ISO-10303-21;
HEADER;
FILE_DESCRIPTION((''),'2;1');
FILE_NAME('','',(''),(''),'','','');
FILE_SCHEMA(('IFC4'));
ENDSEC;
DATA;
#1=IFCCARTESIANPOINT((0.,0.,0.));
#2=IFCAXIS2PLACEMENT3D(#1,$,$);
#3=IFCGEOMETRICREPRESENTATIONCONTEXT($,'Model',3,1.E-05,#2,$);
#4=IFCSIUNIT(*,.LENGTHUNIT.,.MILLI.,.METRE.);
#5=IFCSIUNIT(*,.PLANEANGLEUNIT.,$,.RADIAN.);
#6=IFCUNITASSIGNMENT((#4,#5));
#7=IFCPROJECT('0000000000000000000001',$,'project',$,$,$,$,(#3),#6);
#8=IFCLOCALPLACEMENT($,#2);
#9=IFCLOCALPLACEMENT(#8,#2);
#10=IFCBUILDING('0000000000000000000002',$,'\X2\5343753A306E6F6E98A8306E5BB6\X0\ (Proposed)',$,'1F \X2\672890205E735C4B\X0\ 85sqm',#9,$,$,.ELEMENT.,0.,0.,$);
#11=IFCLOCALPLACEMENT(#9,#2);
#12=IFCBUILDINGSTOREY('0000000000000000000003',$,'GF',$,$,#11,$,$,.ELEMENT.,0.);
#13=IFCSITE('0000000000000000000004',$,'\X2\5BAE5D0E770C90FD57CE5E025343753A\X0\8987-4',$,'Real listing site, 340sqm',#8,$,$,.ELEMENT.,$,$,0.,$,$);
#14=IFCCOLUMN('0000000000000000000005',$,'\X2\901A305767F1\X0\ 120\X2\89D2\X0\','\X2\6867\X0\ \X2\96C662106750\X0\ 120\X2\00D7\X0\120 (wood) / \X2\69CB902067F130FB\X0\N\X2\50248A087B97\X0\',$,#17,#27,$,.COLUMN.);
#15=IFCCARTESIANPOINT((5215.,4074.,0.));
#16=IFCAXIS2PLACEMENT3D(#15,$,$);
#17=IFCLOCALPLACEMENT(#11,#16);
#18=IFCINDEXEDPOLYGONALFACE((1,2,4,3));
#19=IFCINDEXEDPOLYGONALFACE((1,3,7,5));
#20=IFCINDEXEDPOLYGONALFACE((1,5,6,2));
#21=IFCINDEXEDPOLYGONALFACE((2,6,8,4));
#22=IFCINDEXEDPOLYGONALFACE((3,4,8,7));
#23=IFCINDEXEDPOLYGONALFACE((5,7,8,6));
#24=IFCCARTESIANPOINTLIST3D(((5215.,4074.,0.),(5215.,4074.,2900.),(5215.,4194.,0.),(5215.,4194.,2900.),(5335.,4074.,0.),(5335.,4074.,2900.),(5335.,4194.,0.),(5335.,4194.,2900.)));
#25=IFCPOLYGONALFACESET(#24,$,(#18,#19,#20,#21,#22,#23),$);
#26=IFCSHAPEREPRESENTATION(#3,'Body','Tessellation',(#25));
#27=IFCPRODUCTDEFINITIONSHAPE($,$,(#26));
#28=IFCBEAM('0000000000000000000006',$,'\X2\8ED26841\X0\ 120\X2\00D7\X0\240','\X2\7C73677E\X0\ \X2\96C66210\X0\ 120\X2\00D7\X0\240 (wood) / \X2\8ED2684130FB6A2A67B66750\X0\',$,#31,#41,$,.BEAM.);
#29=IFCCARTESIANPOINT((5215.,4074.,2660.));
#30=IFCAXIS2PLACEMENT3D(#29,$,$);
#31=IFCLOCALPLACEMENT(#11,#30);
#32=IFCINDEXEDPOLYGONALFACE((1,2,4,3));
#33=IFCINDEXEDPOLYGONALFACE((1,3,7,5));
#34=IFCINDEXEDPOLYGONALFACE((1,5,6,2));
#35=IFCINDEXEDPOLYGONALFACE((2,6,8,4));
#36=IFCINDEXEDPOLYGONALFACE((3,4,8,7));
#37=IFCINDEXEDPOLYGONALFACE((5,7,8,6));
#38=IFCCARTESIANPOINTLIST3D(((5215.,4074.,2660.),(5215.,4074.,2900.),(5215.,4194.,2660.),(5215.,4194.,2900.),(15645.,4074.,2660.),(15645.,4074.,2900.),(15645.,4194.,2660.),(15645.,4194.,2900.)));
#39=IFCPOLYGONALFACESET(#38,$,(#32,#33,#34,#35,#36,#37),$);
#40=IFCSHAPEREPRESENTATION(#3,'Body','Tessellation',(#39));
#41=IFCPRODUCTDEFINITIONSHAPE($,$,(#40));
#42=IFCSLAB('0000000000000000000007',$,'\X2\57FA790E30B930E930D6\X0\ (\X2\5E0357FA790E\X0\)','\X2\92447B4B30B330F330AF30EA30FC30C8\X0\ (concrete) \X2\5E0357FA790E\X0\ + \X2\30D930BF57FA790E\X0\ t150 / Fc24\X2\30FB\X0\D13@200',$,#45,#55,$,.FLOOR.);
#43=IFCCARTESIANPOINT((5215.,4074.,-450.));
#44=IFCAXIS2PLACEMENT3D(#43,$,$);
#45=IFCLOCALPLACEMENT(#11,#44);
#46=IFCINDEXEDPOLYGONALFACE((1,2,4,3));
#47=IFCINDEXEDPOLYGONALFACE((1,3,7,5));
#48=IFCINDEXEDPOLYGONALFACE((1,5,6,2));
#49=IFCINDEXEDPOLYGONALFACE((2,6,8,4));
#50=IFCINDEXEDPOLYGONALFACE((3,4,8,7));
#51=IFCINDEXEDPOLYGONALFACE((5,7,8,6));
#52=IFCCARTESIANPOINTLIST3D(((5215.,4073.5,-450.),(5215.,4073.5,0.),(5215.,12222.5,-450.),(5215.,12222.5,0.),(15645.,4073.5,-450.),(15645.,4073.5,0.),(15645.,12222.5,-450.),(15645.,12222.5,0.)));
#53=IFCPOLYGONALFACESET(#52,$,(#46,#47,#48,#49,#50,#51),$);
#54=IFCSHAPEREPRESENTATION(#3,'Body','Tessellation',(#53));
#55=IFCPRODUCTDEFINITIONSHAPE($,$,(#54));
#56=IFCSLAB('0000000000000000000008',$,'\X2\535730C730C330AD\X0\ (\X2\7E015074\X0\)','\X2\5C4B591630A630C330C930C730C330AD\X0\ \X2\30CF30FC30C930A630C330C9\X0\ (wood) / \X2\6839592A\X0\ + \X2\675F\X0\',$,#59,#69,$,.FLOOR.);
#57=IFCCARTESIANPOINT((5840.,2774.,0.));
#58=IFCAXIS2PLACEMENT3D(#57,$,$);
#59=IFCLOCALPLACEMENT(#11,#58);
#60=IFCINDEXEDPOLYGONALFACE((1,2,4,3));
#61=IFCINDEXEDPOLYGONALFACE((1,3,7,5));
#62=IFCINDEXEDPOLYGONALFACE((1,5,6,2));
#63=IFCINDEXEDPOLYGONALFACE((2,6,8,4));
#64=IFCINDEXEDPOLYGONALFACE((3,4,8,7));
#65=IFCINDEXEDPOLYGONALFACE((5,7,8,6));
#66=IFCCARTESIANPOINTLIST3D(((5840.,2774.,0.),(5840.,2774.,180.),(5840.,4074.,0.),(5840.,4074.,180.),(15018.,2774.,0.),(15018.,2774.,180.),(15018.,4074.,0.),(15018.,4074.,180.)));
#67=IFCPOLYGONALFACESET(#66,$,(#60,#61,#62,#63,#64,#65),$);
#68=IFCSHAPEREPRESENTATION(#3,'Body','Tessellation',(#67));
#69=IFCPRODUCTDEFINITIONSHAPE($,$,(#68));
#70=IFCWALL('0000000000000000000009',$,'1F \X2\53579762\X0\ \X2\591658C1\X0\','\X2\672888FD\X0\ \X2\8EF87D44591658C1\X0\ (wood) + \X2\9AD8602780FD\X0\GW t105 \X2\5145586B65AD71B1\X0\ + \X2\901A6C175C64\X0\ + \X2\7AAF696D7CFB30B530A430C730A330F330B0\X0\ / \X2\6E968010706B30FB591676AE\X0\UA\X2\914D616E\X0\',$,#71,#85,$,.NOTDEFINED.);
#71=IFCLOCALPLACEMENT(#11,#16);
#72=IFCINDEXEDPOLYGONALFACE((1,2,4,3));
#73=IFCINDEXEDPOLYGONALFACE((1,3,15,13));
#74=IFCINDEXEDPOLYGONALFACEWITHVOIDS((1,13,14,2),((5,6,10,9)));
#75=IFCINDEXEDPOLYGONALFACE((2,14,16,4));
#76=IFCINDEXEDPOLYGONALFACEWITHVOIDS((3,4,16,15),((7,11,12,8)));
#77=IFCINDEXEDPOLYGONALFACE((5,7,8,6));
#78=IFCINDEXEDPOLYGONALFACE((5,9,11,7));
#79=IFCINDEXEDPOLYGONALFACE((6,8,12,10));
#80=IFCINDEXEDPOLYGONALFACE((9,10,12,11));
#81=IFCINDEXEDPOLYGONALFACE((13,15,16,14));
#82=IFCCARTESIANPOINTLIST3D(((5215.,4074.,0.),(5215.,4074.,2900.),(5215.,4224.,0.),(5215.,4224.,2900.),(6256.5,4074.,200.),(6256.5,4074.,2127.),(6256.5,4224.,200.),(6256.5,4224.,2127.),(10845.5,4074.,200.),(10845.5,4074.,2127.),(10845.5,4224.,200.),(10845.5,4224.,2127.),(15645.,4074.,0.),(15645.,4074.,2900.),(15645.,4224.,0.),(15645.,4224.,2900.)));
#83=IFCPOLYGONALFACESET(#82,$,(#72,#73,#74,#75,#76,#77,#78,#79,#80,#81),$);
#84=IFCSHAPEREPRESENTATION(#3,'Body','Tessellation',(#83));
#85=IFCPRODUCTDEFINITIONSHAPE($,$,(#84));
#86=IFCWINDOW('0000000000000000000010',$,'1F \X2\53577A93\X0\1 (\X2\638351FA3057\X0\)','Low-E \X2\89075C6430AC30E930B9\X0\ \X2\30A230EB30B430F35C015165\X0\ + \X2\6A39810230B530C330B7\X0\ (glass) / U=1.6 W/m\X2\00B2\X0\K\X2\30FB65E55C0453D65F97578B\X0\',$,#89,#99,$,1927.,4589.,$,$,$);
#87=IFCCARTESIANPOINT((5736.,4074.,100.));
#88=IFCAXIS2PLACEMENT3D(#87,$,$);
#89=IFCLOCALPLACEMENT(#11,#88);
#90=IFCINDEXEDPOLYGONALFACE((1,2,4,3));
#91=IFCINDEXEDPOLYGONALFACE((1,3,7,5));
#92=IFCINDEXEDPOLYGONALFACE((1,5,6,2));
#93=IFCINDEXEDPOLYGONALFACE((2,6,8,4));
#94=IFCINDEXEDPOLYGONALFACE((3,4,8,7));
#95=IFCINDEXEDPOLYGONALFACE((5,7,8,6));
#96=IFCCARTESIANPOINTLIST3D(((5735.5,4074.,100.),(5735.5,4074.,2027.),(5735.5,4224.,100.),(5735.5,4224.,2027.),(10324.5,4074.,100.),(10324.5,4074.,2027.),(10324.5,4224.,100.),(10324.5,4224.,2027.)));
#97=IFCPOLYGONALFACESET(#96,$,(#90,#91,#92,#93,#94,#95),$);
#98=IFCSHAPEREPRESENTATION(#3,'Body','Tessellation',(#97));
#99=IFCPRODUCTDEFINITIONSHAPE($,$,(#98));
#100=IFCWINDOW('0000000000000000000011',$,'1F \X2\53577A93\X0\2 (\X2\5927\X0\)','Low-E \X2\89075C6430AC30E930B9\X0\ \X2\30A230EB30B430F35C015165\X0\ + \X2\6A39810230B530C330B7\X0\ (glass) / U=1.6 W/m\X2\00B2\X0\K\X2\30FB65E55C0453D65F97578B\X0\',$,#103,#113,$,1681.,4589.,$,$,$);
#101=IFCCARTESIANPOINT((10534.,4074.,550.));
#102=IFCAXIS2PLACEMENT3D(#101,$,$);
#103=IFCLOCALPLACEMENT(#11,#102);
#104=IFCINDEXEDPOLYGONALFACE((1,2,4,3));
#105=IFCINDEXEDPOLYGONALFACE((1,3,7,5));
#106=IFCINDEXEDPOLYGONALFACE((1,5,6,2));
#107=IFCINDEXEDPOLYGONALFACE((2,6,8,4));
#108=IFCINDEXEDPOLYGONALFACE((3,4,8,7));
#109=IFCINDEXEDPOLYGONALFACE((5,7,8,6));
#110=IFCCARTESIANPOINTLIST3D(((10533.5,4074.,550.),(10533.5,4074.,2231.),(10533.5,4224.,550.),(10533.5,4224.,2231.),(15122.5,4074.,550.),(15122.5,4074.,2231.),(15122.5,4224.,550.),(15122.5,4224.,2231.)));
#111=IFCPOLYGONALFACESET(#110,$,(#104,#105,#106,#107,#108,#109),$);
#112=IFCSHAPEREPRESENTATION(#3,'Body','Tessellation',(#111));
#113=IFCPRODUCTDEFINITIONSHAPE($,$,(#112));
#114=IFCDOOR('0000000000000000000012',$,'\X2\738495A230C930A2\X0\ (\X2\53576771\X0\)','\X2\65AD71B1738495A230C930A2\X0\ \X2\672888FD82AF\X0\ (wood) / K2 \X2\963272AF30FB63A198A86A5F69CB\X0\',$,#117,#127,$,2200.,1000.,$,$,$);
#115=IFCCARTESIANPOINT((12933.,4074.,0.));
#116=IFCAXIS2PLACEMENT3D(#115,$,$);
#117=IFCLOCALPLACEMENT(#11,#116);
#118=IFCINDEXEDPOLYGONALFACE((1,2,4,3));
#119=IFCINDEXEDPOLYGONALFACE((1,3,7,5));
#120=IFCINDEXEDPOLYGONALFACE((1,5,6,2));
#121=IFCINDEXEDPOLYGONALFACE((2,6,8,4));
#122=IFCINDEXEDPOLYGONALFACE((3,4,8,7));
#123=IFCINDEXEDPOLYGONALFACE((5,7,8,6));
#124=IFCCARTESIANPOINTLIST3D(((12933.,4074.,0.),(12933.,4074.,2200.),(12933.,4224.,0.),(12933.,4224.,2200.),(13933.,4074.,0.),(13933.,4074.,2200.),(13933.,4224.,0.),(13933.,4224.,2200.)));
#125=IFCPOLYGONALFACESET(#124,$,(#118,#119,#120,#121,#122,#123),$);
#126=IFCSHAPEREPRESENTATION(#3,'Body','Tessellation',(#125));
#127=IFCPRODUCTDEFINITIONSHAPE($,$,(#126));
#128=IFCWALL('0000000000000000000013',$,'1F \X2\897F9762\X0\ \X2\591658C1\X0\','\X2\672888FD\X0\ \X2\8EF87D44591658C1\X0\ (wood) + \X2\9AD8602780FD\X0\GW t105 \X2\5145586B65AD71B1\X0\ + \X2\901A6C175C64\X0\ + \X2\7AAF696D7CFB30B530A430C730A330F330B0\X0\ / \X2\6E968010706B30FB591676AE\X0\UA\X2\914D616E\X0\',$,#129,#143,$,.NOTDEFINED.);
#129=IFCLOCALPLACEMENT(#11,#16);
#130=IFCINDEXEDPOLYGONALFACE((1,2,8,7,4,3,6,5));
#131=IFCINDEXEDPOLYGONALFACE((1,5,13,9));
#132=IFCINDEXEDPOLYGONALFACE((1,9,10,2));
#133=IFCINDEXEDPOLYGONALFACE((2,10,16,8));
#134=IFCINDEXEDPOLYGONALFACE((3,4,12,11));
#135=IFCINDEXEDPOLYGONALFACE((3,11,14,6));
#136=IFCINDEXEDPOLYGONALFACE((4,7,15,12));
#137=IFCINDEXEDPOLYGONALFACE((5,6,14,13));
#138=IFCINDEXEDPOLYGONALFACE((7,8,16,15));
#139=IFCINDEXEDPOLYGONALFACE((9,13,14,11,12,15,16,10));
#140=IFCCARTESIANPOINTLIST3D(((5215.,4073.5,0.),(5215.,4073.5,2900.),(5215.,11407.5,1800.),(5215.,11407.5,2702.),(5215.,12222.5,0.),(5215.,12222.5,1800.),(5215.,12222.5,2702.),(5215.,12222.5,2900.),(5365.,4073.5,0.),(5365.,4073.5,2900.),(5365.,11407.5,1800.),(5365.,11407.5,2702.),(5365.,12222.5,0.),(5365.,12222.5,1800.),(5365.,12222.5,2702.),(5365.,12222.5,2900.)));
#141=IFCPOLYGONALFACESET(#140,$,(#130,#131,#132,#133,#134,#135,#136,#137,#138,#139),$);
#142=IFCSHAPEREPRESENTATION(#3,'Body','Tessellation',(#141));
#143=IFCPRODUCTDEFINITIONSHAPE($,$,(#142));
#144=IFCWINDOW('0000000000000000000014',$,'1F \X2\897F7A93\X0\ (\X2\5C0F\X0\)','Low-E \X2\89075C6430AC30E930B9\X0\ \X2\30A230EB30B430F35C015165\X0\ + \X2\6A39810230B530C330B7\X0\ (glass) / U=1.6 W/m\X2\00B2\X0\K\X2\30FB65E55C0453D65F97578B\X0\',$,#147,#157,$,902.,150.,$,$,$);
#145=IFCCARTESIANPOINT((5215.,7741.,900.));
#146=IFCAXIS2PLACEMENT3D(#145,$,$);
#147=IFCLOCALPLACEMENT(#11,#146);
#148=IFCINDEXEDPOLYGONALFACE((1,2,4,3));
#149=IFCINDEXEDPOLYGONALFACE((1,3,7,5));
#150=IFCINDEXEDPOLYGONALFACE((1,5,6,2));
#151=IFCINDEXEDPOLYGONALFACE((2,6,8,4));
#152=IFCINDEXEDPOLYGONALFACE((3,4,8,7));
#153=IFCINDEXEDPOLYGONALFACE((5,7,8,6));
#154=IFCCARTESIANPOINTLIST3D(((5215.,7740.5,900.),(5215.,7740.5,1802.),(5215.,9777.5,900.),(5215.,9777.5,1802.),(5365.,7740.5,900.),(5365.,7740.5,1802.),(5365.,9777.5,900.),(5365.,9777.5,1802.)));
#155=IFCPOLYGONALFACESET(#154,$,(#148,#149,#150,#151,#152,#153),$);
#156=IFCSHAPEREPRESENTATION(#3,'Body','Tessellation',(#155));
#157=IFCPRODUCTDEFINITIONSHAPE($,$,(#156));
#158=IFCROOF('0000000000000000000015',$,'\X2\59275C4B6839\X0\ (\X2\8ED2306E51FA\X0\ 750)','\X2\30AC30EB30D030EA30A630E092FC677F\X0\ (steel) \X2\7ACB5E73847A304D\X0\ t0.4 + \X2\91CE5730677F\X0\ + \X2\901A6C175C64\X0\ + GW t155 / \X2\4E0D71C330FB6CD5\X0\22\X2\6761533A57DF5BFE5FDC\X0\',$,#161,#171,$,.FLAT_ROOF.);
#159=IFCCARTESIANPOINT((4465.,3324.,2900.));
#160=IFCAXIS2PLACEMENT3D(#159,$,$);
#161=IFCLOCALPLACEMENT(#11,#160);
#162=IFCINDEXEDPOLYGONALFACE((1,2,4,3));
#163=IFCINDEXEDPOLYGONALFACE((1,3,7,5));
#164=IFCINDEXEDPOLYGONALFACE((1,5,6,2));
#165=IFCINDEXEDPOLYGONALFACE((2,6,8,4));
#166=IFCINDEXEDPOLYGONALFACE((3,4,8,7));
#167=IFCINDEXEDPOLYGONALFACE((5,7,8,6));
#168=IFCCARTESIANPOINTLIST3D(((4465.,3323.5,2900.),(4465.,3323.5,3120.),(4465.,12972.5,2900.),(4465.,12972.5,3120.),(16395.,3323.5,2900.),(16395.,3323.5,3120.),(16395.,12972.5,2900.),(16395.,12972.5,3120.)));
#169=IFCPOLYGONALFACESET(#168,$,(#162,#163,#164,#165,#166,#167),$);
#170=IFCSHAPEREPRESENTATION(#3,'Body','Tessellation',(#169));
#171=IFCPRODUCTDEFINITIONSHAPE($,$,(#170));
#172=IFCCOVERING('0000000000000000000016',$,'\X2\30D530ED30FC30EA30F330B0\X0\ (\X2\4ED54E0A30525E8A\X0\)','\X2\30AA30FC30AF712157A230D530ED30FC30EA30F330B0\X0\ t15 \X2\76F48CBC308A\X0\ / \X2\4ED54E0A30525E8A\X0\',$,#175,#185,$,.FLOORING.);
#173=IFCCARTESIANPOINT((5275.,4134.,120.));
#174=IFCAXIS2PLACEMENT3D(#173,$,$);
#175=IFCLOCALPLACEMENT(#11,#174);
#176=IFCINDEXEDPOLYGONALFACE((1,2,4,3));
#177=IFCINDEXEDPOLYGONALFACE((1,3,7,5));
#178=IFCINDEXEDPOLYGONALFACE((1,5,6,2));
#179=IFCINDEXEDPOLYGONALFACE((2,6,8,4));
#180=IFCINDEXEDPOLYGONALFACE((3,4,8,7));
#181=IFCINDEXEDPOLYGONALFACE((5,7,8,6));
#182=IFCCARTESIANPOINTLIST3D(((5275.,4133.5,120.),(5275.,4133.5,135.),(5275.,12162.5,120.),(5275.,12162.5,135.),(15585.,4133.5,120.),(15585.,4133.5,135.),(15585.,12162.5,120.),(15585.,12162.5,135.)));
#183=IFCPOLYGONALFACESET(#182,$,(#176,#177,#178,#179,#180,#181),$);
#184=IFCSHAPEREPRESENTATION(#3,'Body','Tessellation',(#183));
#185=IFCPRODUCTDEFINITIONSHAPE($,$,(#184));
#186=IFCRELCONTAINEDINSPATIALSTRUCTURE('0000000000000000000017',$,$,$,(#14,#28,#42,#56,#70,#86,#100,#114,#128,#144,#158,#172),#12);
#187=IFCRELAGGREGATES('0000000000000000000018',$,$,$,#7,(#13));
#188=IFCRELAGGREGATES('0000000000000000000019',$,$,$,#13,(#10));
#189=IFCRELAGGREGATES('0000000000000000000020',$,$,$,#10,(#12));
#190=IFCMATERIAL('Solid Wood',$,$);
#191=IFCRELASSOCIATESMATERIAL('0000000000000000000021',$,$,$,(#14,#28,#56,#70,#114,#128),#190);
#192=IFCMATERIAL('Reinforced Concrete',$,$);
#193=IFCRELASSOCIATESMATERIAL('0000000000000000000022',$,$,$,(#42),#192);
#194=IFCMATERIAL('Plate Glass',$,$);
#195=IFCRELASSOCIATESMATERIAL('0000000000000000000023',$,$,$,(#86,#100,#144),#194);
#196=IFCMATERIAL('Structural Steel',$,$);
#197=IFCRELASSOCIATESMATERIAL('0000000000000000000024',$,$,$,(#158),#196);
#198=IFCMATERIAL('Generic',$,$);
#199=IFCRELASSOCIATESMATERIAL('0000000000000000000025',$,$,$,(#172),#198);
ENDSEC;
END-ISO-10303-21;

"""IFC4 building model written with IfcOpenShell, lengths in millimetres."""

from ifc_helpers import new_model, si_unit, frame, frame_2d, origin, place, context, project, spatial, rectangle, extrude, material, element, fill, save


model = new_model("IFC4")

# Units and contexts
model_context = context("Model", 3, precision=1e-05, world=origin())
ifc_project = project(units=[si_unit("LENGTHUNIT", "METRE", prefix="MILLI"), si_unit("PLANEANGLEUNIT", "RADIAN")], contexts=[model_context])

# Site, building, storey
site_placement = place(None, origin())
site = spatial("IfcSite", under=ifc_project, at=site_placement, Name="宮崎県都城市千町8987-4", ObjectType="Real listing site, 340sqm", CompositionType="ELEMENT", RefElevation=0.0)
building_placement = place(site_placement, origin())
building = spatial("IfcBuilding", under=site, at=building_placement, Name="千町の潮風の家 (Proposed)", ObjectType="1F 木造平屋 85sqm", CompositionType="ELEMENT", ElevationOfRefHeight=0.0, ElevationOfTerrain=0.0)
storey_placement = place(building_placement, origin())
storey = spatial("IfcBuildingStorey", under=building, at=storey_placement, Name="GF", CompositionType="ELEMENT", Elevation=0.0)

# Column
ifc_material_1 = material(Name="Solid Wood")
column_1_placement = place(storey_placement, frame((5215.0, 4074.0, 0.0)))
element("IfcColumn", 1, at=column_1_placement, inside=storey, material=ifc_material_1, Name="通し柱 120角", Description="桧 集成材 120×120 (wood) / 構造柱・N値計算", PredefinedType="COLUMN", context=model_context, shape_type="SweptSolid", body=[
    extrude(rectangle(XDim=120.0, YDim=120.0, at=frame_2d((60.0, 60.0))), frame((5215.0, 4074.0, 0.0)), (0.0, 0.0, 1.0), 2900.0),
])

# Beam
beam_1_placement = place(storey_placement, frame((5215.0, 4074.0, 2660.0)))
element("IfcBeam", 2, at=beam_1_placement, inside=storey, material=ifc_material_1, Name="軒桁 120×240", Description="米松 集成 120×240 (wood) / 軒桁・横架材", PredefinedType="BEAM", context=model_context, shape_type="SweptSolid", body=[
    extrude(rectangle(XDim=10430.0, YDim=120.0, at=frame_2d((5215.0, 60.0))), frame((5215.0, 4074.0, 2660.0)), (0.0, 0.0, 1.0), 240.0),
])

# Slabs
ifc_material_2 = material(Name="Reinforced Concrete")
slab_1_placement = place(storey_placement, frame((5215.0, 4074.0, -450.0)))
element("IfcSlab", 3, at=slab_1_placement, inside=storey, material=ifc_material_2, Name="基礎スラブ (布基礎)", Description="鉄筋コンクリート (concrete) 布基礎 + ベタ基礎 t150 / Fc24・D13@200", PredefinedType="FLOOR", context=model_context, shape_type="SweptSolid", body=[
    extrude(rectangle(XDim=10430.0, YDim=8149.0, at=frame_2d((5215.0, 4074.0))), frame((5215.0, 4074.0, -450.0)), (0.0, 0.0, 1.0), 450.0),
])
slab_2_placement = place(storey_placement, frame((5840.0, 2774.0, 0.0)))
element("IfcSlab", 4, at=slab_2_placement, inside=storey, material=ifc_material_1, Name="南デッキ (縁側)", Description="屋外ウッドデッキ ハードウッド (wood) / 根太 + 束", PredefinedType="FLOOR", context=model_context, shape_type="SweptSolid", body=[
    extrude(rectangle(XDim=9178.0, YDim=1300.0, at=frame_2d((4589.0, 650.0))), frame((5840.0, 2774.0, 0.0)), (0.0, 0.0, 1.0), 180.0),
])

# Wall, openings, windows, door
wall_1_placement = place(storey_placement, frame((5215.0, 4074.0, 0.0)))
wall_1 = element("IfcWall", 5, at=wall_1_placement, inside=storey, material=ifc_material_1, Name="1F 南面 外壁", Description="木製 軸組外壁 (wood) + 高性能GW t105 充填断熱 + 通気層 + 窯業系サイディング / 準耐火・外皮UA配慮", PredefinedType="NOTDEFINED", context=model_context, shape_type="SweptSolid", body=[
    extrude(rectangle(XDim=10430.0, YDim=150.0, at=frame_2d((5215.0, 75.0))), frame((5215.0, 4074.0, 0.0)), (0.0, 0.0, 1.0), 2900.0),
])
opening_1_placement = place(storey_placement, frame((5736.0, 4074.0, 100.0)))
opening_1 = element("IfcOpeningElement", 6, at=opening_1_placement, cuts=wall_1, PredefinedType="NOTDEFINED", context=model_context, shape_type="SweptSolid", body=[
    extrude(rectangle(XDim=4589.0, YDim=150.0, at=frame_2d((2294.0, 75.0))), frame((5736.0, 4074.0, 100.0)), (0.0, 0.0, 1.0), 1927.0),
])
opening_2_placement = place(storey_placement, frame((10534.0, 4074.0, 550.0)))
opening_2 = element("IfcOpeningElement", 7, at=opening_2_placement, cuts=wall_1, PredefinedType="NOTDEFINED", context=model_context, shape_type="SweptSolid", body=[
    extrude(rectangle(XDim=4589.0, YDim=150.0, at=frame_2d((2294.0, 75.0))), frame((10534.0, 4074.0, 550.0)), (0.0, 0.0, 1.0), 1681.0),
])
opening_3_placement = place(storey_placement, frame((12933.0, 4074.0, 0.0)))
opening_3 = element("IfcOpeningElement", 8, at=opening_3_placement, cuts=wall_1, PredefinedType="NOTDEFINED", context=model_context, shape_type="SweptSolid", body=[
    extrude(rectangle(XDim=1000.0, YDim=150.0, at=frame_2d((500.0, 75.0))), frame((12933.0, 4074.0, 0.0)), (0.0, 0.0, 1.0), 2200.0),
])
ifc_material_3 = material(Name="Plate Glass")
window_1_placement = place(storey_placement, frame((5736.0, 4074.0, 100.0)))
window_1 = element("IfcWindow", 9, at=window_1_placement, inside=storey, material=ifc_material_3, Name="1F 南窓1 (掃出し)", Description="Low-E 複層ガラス アルゴン封入 + 樹脂サッシ (glass) / U=1.6 W/m²K・日射取得型", OverallHeight=1927.0, OverallWidth=4589.0, context=model_context, shape_type="SweptSolid", body=[
    extrude(rectangle(XDim=4589.0, YDim=150.0, at=frame_2d((2294.0, 75.0))), frame((5736.0, 4074.0, 100.0)), (0.0, 0.0, 1.0), 1927.0),
])
fill(opening_1, window_1)
window_2_placement = place(storey_placement, frame((10534.0, 4074.0, 550.0)))
window_2 = element("IfcWindow", 10, at=window_2_placement, inside=storey, material=ifc_material_3, Name="1F 南窓2 (大)", Description="Low-E 複層ガラス アルゴン封入 + 樹脂サッシ (glass) / U=1.6 W/m²K・日射取得型", OverallHeight=1681.0, OverallWidth=4589.0, context=model_context, shape_type="SweptSolid", body=[
    extrude(rectangle(XDim=4589.0, YDim=150.0, at=frame_2d((2294.0, 75.0))), frame((10534.0, 4074.0, 550.0)), (0.0, 0.0, 1.0), 1681.0),
])
fill(opening_2, window_2)
door_placement = place(storey_placement, frame((12933.0, 4074.0, 0.0)))
door = element("IfcDoor", 11, at=door_placement, inside=storey, material=ifc_material_1, Name="玄関ドア (南東)", Description="断熱玄関ドア 木製芯 (wood) / K2 防犯・採風機構", OverallHeight=2200.0, OverallWidth=1000.0, context=model_context, shape_type="SweptSolid", body=[
    extrude(rectangle(XDim=1000.0, YDim=150.0, at=frame_2d((500.0, 75.0))), frame((12933.0, 4074.0, 0.0)), (0.0, 0.0, 1.0), 2200.0),
])
fill(opening_3, door)

# Wall, opening, window
wall_2_placement = place(storey_placement, frame((5215.0, 4074.0, 0.0)))
wall_2 = element("IfcWall", 12, at=wall_2_placement, inside=storey, material=ifc_material_1, Name="1F 西面 外壁", Description="木製 軸組外壁 (wood) + 高性能GW t105 充填断熱 + 通気層 + 窯業系サイディング / 準耐火・外皮UA配慮", PredefinedType="NOTDEFINED", context=model_context, shape_type="SweptSolid", body=[
    extrude(rectangle(XDim=150.0, YDim=8149.0, at=frame_2d((75.0, 4074.0))), frame((5215.0, 4074.0, 0.0)), (0.0, 0.0, 1.0), 2900.0),
])
opening_4_placement = place(storey_placement, frame((5215.0, 7741.0, 900.0)))
opening_4 = element("IfcOpeningElement", 13, at=opening_4_placement, cuts=wall_2, PredefinedType="NOTDEFINED", context=model_context, shape_type="SweptSolid", body=[
    extrude(rectangle(XDim=150.0, YDim=2037.0, at=frame_2d((75.0, 1018.0))), frame((5215.0, 7741.0, 900.0)), (0.0, 0.0, 1.0), 902.0),
])
window_3_placement = place(storey_placement, frame((5215.0, 7741.0, 900.0)))
window_3 = element("IfcWindow", 14, at=window_3_placement, inside=storey, material=ifc_material_3, Name="1F 西窓 (小)", Description="Low-E 複層ガラス アルゴン封入 + 樹脂サッシ (glass) / U=1.6 W/m²K・日射取得型", OverallHeight=902.0, OverallWidth=150.0, context=model_context, shape_type="SweptSolid", body=[
    extrude(rectangle(XDim=150.0, YDim=2037.0, at=frame_2d((75.0, 1018.0))), frame((5215.0, 7741.0, 900.0)), (0.0, 0.0, 1.0), 902.0),
])
fill(opening_4, window_3)

# Roof
ifc_material_4 = material(Name="Structural Steel")
roof_placement = place(storey_placement, frame((4465.0, 3324.0, 2900.0)))
element("IfcRoof", 15, at=roof_placement, inside=storey, material=ifc_material_4, Name="大屋根 (軒の出 750)", Description="ガルバリウム鋼板 (steel) 立平葺き t0.4 + 野地板 + 通気層 + GW t155 / 不燃・法22条区域対応", PredefinedType="FLAT_ROOF", context=model_context, shape_type="SweptSolid", body=[
    extrude(rectangle(XDim=11930.0, YDim=9649.0, at=frame_2d((5965.0, 4824.0))), frame((4465.0, 3324.0, 2900.0)), (0.0, 0.0, 1.0), 220.0),
])

# Covering
ifc_material_5 = material(Name="Generic")
covering_1_placement = place(storey_placement, frame((5275.0, 4134.0, 120.0)))
element("IfcCovering", 16, at=covering_1_placement, inside=storey, material=ifc_material_5, Name="フローリング (仕上げ床)", Description="オーク無垢フローリング t15 直貼り / 仕上げ床", PredefinedType="FLOORING", context=model_context, shape_type="SweptSolid", body=[
    extrude(rectangle(XDim=10310.0, YDim=8029.0, at=frame_2d((5155.0, 4014.0))), frame((5275.0, 4134.0, 120.0)), (0.0, 0.0, 1.0), 15.0),
])

save(model, "model.ifc")
